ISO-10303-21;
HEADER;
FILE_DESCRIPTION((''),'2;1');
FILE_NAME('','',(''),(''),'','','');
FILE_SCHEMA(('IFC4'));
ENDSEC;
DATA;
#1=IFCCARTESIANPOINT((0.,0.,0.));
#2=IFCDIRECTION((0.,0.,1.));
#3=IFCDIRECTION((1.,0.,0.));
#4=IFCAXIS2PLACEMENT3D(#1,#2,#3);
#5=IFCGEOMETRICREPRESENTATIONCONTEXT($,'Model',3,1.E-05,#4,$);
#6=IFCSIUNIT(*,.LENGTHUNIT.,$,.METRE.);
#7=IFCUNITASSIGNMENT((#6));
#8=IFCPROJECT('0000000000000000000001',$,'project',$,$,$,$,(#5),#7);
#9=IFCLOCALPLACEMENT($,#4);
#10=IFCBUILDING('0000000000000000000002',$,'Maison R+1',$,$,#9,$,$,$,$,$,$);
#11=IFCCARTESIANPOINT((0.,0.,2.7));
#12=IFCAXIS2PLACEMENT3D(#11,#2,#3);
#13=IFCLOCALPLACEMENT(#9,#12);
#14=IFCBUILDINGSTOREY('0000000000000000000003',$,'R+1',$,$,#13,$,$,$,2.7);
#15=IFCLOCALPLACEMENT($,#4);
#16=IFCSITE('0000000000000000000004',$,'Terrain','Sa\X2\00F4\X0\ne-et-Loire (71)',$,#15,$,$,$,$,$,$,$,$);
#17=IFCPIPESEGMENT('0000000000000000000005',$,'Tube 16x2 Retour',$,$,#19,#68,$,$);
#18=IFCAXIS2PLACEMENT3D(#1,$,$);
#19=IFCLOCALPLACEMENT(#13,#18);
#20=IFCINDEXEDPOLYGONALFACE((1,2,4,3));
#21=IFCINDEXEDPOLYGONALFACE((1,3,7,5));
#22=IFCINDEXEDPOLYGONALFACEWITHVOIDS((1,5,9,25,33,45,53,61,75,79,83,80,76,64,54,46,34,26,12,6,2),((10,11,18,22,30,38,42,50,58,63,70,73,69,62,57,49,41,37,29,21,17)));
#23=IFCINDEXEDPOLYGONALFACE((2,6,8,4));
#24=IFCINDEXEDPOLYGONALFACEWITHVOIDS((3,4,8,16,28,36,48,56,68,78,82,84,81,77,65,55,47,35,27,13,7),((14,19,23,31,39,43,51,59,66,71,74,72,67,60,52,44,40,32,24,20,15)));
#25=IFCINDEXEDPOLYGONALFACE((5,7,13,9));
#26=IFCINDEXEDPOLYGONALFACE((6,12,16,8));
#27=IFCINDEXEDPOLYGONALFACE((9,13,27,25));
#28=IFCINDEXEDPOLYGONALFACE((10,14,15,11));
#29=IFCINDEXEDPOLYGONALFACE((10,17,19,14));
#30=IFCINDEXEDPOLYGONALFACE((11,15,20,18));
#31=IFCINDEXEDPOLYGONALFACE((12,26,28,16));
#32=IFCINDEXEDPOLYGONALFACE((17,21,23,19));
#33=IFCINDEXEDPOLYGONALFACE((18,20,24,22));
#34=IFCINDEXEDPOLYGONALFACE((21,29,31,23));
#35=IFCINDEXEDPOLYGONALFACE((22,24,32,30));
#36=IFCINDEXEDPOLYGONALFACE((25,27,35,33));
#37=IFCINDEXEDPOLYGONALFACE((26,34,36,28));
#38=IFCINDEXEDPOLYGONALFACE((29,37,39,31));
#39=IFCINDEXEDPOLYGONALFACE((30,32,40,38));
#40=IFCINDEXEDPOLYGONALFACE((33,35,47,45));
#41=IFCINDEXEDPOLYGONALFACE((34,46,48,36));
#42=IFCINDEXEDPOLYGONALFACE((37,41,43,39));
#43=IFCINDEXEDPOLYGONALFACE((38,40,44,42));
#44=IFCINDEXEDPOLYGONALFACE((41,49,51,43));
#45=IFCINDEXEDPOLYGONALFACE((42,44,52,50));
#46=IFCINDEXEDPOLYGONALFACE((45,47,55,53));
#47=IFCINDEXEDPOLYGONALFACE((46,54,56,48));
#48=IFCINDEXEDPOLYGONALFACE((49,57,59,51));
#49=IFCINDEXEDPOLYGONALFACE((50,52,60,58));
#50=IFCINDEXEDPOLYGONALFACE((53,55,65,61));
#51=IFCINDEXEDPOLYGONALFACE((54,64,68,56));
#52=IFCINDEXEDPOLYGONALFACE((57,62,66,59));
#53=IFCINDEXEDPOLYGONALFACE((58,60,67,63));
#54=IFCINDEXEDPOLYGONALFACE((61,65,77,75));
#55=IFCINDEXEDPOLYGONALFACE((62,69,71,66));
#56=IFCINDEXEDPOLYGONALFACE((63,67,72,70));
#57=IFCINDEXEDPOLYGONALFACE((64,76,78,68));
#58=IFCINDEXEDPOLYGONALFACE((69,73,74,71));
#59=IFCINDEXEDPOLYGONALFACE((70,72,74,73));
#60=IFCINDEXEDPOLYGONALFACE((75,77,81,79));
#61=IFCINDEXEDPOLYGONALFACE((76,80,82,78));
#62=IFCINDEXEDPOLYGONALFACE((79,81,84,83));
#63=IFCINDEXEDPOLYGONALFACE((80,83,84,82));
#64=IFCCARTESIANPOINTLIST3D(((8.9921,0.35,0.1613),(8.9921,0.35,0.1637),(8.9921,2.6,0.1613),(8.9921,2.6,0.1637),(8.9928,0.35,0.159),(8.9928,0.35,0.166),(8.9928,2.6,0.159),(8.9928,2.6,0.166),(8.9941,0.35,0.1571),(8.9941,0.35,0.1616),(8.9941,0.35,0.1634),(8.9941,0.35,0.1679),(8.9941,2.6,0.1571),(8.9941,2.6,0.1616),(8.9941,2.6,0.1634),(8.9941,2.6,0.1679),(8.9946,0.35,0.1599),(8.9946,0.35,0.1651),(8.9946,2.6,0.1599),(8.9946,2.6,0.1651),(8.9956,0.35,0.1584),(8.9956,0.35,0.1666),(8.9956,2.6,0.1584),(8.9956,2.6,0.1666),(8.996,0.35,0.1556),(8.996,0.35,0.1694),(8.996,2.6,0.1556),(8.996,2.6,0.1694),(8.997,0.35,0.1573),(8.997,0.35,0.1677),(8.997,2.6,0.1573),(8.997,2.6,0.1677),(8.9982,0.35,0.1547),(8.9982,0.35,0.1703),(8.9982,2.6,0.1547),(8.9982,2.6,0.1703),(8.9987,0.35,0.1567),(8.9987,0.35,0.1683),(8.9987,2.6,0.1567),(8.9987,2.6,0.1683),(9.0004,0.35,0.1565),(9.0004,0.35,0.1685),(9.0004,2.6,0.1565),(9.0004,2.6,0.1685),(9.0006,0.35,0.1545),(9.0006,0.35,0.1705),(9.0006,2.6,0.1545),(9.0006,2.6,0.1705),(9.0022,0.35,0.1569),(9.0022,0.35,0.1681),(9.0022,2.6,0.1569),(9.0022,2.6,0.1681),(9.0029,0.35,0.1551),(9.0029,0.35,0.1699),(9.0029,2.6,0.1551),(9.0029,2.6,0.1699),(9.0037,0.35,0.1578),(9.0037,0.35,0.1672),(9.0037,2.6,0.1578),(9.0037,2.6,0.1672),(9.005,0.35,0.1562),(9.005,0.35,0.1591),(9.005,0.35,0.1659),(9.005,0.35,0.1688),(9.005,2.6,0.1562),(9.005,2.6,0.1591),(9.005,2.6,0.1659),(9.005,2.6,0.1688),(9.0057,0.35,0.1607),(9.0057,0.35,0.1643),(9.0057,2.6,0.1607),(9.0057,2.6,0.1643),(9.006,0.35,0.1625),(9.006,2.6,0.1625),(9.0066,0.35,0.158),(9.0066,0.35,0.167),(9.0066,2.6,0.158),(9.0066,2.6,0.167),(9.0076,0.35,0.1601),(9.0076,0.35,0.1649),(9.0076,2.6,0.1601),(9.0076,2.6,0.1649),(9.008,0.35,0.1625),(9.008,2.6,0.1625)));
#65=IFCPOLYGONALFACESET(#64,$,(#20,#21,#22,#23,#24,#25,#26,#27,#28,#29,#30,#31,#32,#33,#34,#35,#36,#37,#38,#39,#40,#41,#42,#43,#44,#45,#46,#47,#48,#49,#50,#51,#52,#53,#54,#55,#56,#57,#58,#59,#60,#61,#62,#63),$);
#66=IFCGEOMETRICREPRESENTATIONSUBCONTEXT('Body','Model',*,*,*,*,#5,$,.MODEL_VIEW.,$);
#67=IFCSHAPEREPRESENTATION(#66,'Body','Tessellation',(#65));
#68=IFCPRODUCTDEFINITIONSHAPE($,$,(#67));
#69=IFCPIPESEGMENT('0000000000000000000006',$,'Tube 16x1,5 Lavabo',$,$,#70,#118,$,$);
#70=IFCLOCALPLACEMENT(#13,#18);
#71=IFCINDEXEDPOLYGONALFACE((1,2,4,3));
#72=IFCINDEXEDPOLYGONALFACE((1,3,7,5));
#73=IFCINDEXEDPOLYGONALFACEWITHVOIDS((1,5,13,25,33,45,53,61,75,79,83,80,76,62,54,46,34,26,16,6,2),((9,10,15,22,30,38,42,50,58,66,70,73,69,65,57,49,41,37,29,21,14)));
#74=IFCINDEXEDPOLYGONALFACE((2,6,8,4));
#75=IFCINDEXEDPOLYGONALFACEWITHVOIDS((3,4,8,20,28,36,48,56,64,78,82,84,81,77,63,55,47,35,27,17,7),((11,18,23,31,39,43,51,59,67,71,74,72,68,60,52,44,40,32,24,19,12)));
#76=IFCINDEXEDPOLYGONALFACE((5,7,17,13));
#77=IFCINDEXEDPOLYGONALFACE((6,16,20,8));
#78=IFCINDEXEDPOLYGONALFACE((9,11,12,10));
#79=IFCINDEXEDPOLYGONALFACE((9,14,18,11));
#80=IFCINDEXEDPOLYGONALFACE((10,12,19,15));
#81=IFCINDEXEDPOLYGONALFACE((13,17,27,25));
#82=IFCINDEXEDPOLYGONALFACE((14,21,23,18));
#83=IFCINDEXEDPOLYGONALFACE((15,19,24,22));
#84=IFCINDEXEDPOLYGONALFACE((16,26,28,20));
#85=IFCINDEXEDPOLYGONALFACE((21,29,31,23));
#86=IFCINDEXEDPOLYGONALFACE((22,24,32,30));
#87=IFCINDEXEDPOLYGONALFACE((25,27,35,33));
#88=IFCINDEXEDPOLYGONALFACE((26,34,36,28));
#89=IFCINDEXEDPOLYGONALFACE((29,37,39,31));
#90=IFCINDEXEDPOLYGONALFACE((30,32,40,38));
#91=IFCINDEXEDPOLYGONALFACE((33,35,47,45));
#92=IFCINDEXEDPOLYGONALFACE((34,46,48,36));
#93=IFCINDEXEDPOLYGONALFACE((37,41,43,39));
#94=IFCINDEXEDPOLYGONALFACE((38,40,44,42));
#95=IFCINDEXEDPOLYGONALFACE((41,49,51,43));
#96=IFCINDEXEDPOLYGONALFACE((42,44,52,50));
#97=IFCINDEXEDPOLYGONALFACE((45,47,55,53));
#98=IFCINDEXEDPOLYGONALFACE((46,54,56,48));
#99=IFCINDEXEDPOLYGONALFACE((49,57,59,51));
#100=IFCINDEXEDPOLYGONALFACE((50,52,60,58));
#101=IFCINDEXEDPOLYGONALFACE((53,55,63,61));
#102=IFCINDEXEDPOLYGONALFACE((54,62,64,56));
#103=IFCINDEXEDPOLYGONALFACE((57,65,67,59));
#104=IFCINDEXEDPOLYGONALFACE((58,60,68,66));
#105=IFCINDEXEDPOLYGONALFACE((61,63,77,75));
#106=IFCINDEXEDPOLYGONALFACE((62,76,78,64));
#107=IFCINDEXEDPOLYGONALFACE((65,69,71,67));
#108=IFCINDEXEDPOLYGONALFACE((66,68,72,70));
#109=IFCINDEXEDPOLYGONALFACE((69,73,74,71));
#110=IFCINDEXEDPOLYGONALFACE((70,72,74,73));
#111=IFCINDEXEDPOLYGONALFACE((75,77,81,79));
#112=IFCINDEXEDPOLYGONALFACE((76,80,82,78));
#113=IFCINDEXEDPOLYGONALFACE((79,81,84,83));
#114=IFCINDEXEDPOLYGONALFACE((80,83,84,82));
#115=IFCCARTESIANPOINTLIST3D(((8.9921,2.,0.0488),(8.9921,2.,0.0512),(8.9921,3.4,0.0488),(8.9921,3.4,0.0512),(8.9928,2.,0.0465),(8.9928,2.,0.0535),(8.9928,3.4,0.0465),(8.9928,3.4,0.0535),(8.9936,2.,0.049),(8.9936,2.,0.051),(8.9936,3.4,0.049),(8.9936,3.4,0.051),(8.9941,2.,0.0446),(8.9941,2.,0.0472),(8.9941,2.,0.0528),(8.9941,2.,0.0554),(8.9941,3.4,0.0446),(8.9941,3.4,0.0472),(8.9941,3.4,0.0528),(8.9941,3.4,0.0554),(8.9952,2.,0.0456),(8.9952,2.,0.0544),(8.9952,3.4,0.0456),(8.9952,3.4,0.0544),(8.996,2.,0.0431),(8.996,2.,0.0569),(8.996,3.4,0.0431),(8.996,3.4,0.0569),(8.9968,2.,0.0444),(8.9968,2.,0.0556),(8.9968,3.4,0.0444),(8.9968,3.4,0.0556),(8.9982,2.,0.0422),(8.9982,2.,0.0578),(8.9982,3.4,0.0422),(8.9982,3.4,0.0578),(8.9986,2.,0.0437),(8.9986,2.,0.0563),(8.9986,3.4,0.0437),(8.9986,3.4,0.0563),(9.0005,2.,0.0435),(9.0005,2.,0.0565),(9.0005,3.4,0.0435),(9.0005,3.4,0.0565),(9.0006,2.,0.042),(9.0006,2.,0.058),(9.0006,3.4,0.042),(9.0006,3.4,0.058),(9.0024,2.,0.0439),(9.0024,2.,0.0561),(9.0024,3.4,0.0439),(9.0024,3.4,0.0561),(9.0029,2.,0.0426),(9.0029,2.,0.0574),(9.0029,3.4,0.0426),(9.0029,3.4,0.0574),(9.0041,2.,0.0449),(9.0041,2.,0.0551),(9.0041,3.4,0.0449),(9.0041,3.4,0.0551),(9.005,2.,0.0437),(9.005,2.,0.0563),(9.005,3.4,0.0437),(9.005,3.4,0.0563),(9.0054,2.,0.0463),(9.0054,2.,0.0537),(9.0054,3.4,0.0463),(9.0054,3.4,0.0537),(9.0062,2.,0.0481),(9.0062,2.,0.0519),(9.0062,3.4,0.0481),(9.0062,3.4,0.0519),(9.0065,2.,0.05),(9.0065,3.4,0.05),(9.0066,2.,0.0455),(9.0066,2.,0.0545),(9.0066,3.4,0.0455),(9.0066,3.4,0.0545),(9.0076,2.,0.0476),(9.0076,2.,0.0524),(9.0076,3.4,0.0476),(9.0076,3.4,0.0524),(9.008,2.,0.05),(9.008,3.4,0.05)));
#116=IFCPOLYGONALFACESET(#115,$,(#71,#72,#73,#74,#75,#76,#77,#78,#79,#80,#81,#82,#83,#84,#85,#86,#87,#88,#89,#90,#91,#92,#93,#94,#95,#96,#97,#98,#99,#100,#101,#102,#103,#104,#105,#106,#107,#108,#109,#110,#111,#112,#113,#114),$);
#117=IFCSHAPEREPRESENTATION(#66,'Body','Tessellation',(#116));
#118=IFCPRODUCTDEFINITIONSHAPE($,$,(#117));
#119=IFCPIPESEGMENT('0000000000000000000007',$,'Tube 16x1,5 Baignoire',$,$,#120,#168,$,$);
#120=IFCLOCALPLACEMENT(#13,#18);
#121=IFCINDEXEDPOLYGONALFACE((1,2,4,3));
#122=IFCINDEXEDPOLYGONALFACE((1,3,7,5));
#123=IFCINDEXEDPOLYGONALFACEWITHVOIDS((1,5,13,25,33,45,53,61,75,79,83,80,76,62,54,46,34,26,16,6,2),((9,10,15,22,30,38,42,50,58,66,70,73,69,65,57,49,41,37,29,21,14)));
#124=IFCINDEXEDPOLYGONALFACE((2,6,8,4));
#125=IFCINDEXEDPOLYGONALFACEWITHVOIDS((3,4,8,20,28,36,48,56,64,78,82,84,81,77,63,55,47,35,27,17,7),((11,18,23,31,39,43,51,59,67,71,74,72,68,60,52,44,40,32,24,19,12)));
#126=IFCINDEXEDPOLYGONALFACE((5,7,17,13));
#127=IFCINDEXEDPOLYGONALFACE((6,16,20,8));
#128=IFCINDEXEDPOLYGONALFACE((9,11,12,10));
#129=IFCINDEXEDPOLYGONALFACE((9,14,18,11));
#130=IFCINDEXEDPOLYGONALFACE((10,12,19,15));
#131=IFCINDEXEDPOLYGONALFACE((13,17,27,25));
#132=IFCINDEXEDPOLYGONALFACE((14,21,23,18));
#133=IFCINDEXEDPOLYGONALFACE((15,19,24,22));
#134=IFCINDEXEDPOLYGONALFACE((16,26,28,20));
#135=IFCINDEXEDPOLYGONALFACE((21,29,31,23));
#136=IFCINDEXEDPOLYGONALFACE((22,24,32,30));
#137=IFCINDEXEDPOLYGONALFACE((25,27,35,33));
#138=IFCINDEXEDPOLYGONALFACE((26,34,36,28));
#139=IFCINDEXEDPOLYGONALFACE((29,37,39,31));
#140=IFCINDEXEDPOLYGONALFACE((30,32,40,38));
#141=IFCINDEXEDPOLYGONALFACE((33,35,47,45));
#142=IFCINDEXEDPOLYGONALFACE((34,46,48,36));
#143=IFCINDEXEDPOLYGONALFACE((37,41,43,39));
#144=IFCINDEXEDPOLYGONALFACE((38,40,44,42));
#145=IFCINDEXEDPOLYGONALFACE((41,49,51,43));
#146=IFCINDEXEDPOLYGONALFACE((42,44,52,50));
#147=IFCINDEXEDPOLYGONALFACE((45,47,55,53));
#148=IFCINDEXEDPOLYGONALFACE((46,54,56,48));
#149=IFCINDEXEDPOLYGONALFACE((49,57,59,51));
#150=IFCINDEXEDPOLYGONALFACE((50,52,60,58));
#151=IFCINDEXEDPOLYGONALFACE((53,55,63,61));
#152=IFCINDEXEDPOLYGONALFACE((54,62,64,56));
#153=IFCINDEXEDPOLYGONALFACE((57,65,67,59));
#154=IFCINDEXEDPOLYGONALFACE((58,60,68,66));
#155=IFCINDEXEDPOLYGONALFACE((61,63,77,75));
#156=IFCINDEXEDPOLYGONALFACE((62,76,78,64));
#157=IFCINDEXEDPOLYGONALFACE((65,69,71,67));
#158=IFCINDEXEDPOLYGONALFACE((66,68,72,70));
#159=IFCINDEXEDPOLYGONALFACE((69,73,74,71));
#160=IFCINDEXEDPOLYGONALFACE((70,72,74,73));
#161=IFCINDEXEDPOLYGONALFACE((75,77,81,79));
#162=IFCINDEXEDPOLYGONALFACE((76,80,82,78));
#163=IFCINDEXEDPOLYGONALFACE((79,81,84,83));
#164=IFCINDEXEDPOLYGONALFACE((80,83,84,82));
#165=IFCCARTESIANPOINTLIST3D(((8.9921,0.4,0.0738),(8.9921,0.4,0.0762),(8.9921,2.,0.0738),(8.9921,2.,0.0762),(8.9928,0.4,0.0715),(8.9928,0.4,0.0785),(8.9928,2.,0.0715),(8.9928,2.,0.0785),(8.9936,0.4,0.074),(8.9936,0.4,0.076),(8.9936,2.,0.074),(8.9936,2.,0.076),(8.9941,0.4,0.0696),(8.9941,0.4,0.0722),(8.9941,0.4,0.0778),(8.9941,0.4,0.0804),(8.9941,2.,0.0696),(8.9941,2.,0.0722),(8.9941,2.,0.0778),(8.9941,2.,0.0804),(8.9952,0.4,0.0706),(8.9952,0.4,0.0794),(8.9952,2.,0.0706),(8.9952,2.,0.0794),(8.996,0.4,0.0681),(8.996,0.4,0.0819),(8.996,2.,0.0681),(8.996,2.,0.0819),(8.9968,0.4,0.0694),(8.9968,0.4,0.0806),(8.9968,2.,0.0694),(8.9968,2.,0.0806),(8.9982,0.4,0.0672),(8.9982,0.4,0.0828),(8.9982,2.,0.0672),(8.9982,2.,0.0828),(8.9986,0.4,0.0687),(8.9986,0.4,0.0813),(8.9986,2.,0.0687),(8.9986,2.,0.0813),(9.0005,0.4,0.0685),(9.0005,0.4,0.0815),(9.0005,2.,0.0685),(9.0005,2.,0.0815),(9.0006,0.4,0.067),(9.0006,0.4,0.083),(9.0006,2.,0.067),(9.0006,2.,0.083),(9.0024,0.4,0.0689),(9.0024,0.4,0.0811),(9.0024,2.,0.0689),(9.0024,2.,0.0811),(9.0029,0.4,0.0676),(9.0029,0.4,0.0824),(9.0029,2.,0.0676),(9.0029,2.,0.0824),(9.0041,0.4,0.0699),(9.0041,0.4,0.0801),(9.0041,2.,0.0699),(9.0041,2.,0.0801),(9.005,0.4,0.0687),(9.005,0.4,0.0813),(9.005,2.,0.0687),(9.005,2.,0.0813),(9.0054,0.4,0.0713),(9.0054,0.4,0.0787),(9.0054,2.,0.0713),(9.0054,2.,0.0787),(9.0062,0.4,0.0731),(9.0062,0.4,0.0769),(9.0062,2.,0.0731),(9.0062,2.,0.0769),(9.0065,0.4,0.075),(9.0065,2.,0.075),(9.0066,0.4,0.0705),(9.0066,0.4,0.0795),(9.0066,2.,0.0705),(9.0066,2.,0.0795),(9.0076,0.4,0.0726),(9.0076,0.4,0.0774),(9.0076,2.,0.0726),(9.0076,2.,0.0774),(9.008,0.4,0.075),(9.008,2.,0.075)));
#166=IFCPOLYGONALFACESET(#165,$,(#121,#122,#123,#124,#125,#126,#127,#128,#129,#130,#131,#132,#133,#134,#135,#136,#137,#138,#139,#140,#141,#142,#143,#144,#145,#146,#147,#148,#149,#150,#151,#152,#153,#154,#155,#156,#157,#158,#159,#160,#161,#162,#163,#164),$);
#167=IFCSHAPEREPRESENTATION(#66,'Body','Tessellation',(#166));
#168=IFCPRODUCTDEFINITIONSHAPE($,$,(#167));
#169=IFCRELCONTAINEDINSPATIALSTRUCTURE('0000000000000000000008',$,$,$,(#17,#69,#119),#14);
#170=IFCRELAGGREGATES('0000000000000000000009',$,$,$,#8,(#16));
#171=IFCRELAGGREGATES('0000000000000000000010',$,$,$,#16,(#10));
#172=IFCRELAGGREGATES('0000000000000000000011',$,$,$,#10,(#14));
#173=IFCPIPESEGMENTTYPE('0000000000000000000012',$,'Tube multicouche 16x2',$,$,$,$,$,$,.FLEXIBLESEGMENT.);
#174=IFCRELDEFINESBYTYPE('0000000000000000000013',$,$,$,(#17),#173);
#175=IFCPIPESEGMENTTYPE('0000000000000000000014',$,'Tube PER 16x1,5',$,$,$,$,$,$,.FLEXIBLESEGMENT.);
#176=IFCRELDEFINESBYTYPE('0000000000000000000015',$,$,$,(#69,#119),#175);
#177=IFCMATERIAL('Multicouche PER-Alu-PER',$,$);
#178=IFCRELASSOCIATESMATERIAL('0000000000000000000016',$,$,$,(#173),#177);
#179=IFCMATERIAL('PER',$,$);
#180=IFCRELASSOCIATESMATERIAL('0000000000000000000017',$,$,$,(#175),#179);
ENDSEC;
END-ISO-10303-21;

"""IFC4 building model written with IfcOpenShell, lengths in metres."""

from ifc_helpers import new_model, si_unit, frame, origin_with_axes, place, context, subcontext, project, spatial, hollow_circle, extrude, material, type_object, element, save


model = new_model("IFC4")

# Units and contexts
model_context = context("Model", 3, precision=1e-05, world=origin_with_axes())
body_context = subcontext(model_context, "Body", "Model", "MODEL_VIEW")
ifc_project = project(units=[si_unit("LENGTHUNIT", "METRE")], contexts=[model_context])

# Site, building, storey
site_placement = place(None, origin_with_axes())
site = spatial("IfcSite", under=ifc_project, at=site_placement, Name="Terrain", Description="Saône-et-Loire (71)")
building_placement = place(None, origin_with_axes())
building = spatial("IfcBuilding", under=site, at=building_placement, Name="Maison R+1")
storey_placement = place(building_placement, frame((0.0, 0.0, 2.7), z_axis=(0.0, 0.0, 1.0), x_axis=(1.0, 0.0, 0.0)))
storey = spatial("IfcBuildingStorey", under=building, at=storey_placement, Name="R+1", Elevation=2.7)

# Pipe segments
ifc_material_1 = material(Name="Multicouche PER-Alu-PER")
pipe_segment_type_1 = type_object("IfcPipeSegmentType", Name="Tube multicouche 16x2", PredefinedType="FLEXIBLESEGMENT", material=ifc_material_1)
pipe_segment_1_placement = place(storey_placement, frame((9.0, 0.35, 0.1625), z_axis=(0.0, 1.0, 0.0), x_axis=(1.0, 0.0, 0.0)))
element("IfcPipeSegment", 1, at=pipe_segment_1_placement, inside=storey, type_object=pipe_segment_type_1, Name="Tube 16x2 Retour", context=body_context, shape_type="SweptSolid", body=[
    extrude(hollow_circle(Radius=0.008, WallThickness=0.002), origin_with_axes(), (0.0, 0.0, 1.0), 2.25),
])
ifc_material_2 = material(Name="PER")
pipe_segment_type_2 = type_object("IfcPipeSegmentType", Name="Tube PER 16x1,5", PredefinedType="FLEXIBLESEGMENT", material=ifc_material_2)
pipe_segment_2_placement = place(storey_placement, frame((9.0, 2.0, 0.05), z_axis=(0.0, 1.0, 0.0), x_axis=(1.0, 0.0, 0.0)))
element("IfcPipeSegment", 2, at=pipe_segment_2_placement, inside=storey, type_object=pipe_segment_type_2, Name="Tube 16x1,5 Lavabo", context=body_context, shape_type="SweptSolid", body=[
    extrude(hollow_circle(Radius=0.008, WallThickness=0.0015), origin_with_axes(), (0.0, 0.0, 1.0), 1.4),
])
pipe_segment_3_placement = place(storey_placement, frame((9.0, 2.0, 0.075), z_axis=(0.0, -1.0, 0.0), x_axis=(1.0, 0.0, 0.0)))
element("IfcPipeSegment", 3, at=pipe_segment_3_placement, inside=storey, type_object=pipe_segment_type_2, Name="Tube 16x1,5 Baignoire", context=body_context, shape_type="SweptSolid", body=[
    extrude(hollow_circle(Radius=0.008, WallThickness=0.0015), origin_with_axes(), (0.0, 0.0, 1.0), 1.6),
])

save(model, "model.ifc")
